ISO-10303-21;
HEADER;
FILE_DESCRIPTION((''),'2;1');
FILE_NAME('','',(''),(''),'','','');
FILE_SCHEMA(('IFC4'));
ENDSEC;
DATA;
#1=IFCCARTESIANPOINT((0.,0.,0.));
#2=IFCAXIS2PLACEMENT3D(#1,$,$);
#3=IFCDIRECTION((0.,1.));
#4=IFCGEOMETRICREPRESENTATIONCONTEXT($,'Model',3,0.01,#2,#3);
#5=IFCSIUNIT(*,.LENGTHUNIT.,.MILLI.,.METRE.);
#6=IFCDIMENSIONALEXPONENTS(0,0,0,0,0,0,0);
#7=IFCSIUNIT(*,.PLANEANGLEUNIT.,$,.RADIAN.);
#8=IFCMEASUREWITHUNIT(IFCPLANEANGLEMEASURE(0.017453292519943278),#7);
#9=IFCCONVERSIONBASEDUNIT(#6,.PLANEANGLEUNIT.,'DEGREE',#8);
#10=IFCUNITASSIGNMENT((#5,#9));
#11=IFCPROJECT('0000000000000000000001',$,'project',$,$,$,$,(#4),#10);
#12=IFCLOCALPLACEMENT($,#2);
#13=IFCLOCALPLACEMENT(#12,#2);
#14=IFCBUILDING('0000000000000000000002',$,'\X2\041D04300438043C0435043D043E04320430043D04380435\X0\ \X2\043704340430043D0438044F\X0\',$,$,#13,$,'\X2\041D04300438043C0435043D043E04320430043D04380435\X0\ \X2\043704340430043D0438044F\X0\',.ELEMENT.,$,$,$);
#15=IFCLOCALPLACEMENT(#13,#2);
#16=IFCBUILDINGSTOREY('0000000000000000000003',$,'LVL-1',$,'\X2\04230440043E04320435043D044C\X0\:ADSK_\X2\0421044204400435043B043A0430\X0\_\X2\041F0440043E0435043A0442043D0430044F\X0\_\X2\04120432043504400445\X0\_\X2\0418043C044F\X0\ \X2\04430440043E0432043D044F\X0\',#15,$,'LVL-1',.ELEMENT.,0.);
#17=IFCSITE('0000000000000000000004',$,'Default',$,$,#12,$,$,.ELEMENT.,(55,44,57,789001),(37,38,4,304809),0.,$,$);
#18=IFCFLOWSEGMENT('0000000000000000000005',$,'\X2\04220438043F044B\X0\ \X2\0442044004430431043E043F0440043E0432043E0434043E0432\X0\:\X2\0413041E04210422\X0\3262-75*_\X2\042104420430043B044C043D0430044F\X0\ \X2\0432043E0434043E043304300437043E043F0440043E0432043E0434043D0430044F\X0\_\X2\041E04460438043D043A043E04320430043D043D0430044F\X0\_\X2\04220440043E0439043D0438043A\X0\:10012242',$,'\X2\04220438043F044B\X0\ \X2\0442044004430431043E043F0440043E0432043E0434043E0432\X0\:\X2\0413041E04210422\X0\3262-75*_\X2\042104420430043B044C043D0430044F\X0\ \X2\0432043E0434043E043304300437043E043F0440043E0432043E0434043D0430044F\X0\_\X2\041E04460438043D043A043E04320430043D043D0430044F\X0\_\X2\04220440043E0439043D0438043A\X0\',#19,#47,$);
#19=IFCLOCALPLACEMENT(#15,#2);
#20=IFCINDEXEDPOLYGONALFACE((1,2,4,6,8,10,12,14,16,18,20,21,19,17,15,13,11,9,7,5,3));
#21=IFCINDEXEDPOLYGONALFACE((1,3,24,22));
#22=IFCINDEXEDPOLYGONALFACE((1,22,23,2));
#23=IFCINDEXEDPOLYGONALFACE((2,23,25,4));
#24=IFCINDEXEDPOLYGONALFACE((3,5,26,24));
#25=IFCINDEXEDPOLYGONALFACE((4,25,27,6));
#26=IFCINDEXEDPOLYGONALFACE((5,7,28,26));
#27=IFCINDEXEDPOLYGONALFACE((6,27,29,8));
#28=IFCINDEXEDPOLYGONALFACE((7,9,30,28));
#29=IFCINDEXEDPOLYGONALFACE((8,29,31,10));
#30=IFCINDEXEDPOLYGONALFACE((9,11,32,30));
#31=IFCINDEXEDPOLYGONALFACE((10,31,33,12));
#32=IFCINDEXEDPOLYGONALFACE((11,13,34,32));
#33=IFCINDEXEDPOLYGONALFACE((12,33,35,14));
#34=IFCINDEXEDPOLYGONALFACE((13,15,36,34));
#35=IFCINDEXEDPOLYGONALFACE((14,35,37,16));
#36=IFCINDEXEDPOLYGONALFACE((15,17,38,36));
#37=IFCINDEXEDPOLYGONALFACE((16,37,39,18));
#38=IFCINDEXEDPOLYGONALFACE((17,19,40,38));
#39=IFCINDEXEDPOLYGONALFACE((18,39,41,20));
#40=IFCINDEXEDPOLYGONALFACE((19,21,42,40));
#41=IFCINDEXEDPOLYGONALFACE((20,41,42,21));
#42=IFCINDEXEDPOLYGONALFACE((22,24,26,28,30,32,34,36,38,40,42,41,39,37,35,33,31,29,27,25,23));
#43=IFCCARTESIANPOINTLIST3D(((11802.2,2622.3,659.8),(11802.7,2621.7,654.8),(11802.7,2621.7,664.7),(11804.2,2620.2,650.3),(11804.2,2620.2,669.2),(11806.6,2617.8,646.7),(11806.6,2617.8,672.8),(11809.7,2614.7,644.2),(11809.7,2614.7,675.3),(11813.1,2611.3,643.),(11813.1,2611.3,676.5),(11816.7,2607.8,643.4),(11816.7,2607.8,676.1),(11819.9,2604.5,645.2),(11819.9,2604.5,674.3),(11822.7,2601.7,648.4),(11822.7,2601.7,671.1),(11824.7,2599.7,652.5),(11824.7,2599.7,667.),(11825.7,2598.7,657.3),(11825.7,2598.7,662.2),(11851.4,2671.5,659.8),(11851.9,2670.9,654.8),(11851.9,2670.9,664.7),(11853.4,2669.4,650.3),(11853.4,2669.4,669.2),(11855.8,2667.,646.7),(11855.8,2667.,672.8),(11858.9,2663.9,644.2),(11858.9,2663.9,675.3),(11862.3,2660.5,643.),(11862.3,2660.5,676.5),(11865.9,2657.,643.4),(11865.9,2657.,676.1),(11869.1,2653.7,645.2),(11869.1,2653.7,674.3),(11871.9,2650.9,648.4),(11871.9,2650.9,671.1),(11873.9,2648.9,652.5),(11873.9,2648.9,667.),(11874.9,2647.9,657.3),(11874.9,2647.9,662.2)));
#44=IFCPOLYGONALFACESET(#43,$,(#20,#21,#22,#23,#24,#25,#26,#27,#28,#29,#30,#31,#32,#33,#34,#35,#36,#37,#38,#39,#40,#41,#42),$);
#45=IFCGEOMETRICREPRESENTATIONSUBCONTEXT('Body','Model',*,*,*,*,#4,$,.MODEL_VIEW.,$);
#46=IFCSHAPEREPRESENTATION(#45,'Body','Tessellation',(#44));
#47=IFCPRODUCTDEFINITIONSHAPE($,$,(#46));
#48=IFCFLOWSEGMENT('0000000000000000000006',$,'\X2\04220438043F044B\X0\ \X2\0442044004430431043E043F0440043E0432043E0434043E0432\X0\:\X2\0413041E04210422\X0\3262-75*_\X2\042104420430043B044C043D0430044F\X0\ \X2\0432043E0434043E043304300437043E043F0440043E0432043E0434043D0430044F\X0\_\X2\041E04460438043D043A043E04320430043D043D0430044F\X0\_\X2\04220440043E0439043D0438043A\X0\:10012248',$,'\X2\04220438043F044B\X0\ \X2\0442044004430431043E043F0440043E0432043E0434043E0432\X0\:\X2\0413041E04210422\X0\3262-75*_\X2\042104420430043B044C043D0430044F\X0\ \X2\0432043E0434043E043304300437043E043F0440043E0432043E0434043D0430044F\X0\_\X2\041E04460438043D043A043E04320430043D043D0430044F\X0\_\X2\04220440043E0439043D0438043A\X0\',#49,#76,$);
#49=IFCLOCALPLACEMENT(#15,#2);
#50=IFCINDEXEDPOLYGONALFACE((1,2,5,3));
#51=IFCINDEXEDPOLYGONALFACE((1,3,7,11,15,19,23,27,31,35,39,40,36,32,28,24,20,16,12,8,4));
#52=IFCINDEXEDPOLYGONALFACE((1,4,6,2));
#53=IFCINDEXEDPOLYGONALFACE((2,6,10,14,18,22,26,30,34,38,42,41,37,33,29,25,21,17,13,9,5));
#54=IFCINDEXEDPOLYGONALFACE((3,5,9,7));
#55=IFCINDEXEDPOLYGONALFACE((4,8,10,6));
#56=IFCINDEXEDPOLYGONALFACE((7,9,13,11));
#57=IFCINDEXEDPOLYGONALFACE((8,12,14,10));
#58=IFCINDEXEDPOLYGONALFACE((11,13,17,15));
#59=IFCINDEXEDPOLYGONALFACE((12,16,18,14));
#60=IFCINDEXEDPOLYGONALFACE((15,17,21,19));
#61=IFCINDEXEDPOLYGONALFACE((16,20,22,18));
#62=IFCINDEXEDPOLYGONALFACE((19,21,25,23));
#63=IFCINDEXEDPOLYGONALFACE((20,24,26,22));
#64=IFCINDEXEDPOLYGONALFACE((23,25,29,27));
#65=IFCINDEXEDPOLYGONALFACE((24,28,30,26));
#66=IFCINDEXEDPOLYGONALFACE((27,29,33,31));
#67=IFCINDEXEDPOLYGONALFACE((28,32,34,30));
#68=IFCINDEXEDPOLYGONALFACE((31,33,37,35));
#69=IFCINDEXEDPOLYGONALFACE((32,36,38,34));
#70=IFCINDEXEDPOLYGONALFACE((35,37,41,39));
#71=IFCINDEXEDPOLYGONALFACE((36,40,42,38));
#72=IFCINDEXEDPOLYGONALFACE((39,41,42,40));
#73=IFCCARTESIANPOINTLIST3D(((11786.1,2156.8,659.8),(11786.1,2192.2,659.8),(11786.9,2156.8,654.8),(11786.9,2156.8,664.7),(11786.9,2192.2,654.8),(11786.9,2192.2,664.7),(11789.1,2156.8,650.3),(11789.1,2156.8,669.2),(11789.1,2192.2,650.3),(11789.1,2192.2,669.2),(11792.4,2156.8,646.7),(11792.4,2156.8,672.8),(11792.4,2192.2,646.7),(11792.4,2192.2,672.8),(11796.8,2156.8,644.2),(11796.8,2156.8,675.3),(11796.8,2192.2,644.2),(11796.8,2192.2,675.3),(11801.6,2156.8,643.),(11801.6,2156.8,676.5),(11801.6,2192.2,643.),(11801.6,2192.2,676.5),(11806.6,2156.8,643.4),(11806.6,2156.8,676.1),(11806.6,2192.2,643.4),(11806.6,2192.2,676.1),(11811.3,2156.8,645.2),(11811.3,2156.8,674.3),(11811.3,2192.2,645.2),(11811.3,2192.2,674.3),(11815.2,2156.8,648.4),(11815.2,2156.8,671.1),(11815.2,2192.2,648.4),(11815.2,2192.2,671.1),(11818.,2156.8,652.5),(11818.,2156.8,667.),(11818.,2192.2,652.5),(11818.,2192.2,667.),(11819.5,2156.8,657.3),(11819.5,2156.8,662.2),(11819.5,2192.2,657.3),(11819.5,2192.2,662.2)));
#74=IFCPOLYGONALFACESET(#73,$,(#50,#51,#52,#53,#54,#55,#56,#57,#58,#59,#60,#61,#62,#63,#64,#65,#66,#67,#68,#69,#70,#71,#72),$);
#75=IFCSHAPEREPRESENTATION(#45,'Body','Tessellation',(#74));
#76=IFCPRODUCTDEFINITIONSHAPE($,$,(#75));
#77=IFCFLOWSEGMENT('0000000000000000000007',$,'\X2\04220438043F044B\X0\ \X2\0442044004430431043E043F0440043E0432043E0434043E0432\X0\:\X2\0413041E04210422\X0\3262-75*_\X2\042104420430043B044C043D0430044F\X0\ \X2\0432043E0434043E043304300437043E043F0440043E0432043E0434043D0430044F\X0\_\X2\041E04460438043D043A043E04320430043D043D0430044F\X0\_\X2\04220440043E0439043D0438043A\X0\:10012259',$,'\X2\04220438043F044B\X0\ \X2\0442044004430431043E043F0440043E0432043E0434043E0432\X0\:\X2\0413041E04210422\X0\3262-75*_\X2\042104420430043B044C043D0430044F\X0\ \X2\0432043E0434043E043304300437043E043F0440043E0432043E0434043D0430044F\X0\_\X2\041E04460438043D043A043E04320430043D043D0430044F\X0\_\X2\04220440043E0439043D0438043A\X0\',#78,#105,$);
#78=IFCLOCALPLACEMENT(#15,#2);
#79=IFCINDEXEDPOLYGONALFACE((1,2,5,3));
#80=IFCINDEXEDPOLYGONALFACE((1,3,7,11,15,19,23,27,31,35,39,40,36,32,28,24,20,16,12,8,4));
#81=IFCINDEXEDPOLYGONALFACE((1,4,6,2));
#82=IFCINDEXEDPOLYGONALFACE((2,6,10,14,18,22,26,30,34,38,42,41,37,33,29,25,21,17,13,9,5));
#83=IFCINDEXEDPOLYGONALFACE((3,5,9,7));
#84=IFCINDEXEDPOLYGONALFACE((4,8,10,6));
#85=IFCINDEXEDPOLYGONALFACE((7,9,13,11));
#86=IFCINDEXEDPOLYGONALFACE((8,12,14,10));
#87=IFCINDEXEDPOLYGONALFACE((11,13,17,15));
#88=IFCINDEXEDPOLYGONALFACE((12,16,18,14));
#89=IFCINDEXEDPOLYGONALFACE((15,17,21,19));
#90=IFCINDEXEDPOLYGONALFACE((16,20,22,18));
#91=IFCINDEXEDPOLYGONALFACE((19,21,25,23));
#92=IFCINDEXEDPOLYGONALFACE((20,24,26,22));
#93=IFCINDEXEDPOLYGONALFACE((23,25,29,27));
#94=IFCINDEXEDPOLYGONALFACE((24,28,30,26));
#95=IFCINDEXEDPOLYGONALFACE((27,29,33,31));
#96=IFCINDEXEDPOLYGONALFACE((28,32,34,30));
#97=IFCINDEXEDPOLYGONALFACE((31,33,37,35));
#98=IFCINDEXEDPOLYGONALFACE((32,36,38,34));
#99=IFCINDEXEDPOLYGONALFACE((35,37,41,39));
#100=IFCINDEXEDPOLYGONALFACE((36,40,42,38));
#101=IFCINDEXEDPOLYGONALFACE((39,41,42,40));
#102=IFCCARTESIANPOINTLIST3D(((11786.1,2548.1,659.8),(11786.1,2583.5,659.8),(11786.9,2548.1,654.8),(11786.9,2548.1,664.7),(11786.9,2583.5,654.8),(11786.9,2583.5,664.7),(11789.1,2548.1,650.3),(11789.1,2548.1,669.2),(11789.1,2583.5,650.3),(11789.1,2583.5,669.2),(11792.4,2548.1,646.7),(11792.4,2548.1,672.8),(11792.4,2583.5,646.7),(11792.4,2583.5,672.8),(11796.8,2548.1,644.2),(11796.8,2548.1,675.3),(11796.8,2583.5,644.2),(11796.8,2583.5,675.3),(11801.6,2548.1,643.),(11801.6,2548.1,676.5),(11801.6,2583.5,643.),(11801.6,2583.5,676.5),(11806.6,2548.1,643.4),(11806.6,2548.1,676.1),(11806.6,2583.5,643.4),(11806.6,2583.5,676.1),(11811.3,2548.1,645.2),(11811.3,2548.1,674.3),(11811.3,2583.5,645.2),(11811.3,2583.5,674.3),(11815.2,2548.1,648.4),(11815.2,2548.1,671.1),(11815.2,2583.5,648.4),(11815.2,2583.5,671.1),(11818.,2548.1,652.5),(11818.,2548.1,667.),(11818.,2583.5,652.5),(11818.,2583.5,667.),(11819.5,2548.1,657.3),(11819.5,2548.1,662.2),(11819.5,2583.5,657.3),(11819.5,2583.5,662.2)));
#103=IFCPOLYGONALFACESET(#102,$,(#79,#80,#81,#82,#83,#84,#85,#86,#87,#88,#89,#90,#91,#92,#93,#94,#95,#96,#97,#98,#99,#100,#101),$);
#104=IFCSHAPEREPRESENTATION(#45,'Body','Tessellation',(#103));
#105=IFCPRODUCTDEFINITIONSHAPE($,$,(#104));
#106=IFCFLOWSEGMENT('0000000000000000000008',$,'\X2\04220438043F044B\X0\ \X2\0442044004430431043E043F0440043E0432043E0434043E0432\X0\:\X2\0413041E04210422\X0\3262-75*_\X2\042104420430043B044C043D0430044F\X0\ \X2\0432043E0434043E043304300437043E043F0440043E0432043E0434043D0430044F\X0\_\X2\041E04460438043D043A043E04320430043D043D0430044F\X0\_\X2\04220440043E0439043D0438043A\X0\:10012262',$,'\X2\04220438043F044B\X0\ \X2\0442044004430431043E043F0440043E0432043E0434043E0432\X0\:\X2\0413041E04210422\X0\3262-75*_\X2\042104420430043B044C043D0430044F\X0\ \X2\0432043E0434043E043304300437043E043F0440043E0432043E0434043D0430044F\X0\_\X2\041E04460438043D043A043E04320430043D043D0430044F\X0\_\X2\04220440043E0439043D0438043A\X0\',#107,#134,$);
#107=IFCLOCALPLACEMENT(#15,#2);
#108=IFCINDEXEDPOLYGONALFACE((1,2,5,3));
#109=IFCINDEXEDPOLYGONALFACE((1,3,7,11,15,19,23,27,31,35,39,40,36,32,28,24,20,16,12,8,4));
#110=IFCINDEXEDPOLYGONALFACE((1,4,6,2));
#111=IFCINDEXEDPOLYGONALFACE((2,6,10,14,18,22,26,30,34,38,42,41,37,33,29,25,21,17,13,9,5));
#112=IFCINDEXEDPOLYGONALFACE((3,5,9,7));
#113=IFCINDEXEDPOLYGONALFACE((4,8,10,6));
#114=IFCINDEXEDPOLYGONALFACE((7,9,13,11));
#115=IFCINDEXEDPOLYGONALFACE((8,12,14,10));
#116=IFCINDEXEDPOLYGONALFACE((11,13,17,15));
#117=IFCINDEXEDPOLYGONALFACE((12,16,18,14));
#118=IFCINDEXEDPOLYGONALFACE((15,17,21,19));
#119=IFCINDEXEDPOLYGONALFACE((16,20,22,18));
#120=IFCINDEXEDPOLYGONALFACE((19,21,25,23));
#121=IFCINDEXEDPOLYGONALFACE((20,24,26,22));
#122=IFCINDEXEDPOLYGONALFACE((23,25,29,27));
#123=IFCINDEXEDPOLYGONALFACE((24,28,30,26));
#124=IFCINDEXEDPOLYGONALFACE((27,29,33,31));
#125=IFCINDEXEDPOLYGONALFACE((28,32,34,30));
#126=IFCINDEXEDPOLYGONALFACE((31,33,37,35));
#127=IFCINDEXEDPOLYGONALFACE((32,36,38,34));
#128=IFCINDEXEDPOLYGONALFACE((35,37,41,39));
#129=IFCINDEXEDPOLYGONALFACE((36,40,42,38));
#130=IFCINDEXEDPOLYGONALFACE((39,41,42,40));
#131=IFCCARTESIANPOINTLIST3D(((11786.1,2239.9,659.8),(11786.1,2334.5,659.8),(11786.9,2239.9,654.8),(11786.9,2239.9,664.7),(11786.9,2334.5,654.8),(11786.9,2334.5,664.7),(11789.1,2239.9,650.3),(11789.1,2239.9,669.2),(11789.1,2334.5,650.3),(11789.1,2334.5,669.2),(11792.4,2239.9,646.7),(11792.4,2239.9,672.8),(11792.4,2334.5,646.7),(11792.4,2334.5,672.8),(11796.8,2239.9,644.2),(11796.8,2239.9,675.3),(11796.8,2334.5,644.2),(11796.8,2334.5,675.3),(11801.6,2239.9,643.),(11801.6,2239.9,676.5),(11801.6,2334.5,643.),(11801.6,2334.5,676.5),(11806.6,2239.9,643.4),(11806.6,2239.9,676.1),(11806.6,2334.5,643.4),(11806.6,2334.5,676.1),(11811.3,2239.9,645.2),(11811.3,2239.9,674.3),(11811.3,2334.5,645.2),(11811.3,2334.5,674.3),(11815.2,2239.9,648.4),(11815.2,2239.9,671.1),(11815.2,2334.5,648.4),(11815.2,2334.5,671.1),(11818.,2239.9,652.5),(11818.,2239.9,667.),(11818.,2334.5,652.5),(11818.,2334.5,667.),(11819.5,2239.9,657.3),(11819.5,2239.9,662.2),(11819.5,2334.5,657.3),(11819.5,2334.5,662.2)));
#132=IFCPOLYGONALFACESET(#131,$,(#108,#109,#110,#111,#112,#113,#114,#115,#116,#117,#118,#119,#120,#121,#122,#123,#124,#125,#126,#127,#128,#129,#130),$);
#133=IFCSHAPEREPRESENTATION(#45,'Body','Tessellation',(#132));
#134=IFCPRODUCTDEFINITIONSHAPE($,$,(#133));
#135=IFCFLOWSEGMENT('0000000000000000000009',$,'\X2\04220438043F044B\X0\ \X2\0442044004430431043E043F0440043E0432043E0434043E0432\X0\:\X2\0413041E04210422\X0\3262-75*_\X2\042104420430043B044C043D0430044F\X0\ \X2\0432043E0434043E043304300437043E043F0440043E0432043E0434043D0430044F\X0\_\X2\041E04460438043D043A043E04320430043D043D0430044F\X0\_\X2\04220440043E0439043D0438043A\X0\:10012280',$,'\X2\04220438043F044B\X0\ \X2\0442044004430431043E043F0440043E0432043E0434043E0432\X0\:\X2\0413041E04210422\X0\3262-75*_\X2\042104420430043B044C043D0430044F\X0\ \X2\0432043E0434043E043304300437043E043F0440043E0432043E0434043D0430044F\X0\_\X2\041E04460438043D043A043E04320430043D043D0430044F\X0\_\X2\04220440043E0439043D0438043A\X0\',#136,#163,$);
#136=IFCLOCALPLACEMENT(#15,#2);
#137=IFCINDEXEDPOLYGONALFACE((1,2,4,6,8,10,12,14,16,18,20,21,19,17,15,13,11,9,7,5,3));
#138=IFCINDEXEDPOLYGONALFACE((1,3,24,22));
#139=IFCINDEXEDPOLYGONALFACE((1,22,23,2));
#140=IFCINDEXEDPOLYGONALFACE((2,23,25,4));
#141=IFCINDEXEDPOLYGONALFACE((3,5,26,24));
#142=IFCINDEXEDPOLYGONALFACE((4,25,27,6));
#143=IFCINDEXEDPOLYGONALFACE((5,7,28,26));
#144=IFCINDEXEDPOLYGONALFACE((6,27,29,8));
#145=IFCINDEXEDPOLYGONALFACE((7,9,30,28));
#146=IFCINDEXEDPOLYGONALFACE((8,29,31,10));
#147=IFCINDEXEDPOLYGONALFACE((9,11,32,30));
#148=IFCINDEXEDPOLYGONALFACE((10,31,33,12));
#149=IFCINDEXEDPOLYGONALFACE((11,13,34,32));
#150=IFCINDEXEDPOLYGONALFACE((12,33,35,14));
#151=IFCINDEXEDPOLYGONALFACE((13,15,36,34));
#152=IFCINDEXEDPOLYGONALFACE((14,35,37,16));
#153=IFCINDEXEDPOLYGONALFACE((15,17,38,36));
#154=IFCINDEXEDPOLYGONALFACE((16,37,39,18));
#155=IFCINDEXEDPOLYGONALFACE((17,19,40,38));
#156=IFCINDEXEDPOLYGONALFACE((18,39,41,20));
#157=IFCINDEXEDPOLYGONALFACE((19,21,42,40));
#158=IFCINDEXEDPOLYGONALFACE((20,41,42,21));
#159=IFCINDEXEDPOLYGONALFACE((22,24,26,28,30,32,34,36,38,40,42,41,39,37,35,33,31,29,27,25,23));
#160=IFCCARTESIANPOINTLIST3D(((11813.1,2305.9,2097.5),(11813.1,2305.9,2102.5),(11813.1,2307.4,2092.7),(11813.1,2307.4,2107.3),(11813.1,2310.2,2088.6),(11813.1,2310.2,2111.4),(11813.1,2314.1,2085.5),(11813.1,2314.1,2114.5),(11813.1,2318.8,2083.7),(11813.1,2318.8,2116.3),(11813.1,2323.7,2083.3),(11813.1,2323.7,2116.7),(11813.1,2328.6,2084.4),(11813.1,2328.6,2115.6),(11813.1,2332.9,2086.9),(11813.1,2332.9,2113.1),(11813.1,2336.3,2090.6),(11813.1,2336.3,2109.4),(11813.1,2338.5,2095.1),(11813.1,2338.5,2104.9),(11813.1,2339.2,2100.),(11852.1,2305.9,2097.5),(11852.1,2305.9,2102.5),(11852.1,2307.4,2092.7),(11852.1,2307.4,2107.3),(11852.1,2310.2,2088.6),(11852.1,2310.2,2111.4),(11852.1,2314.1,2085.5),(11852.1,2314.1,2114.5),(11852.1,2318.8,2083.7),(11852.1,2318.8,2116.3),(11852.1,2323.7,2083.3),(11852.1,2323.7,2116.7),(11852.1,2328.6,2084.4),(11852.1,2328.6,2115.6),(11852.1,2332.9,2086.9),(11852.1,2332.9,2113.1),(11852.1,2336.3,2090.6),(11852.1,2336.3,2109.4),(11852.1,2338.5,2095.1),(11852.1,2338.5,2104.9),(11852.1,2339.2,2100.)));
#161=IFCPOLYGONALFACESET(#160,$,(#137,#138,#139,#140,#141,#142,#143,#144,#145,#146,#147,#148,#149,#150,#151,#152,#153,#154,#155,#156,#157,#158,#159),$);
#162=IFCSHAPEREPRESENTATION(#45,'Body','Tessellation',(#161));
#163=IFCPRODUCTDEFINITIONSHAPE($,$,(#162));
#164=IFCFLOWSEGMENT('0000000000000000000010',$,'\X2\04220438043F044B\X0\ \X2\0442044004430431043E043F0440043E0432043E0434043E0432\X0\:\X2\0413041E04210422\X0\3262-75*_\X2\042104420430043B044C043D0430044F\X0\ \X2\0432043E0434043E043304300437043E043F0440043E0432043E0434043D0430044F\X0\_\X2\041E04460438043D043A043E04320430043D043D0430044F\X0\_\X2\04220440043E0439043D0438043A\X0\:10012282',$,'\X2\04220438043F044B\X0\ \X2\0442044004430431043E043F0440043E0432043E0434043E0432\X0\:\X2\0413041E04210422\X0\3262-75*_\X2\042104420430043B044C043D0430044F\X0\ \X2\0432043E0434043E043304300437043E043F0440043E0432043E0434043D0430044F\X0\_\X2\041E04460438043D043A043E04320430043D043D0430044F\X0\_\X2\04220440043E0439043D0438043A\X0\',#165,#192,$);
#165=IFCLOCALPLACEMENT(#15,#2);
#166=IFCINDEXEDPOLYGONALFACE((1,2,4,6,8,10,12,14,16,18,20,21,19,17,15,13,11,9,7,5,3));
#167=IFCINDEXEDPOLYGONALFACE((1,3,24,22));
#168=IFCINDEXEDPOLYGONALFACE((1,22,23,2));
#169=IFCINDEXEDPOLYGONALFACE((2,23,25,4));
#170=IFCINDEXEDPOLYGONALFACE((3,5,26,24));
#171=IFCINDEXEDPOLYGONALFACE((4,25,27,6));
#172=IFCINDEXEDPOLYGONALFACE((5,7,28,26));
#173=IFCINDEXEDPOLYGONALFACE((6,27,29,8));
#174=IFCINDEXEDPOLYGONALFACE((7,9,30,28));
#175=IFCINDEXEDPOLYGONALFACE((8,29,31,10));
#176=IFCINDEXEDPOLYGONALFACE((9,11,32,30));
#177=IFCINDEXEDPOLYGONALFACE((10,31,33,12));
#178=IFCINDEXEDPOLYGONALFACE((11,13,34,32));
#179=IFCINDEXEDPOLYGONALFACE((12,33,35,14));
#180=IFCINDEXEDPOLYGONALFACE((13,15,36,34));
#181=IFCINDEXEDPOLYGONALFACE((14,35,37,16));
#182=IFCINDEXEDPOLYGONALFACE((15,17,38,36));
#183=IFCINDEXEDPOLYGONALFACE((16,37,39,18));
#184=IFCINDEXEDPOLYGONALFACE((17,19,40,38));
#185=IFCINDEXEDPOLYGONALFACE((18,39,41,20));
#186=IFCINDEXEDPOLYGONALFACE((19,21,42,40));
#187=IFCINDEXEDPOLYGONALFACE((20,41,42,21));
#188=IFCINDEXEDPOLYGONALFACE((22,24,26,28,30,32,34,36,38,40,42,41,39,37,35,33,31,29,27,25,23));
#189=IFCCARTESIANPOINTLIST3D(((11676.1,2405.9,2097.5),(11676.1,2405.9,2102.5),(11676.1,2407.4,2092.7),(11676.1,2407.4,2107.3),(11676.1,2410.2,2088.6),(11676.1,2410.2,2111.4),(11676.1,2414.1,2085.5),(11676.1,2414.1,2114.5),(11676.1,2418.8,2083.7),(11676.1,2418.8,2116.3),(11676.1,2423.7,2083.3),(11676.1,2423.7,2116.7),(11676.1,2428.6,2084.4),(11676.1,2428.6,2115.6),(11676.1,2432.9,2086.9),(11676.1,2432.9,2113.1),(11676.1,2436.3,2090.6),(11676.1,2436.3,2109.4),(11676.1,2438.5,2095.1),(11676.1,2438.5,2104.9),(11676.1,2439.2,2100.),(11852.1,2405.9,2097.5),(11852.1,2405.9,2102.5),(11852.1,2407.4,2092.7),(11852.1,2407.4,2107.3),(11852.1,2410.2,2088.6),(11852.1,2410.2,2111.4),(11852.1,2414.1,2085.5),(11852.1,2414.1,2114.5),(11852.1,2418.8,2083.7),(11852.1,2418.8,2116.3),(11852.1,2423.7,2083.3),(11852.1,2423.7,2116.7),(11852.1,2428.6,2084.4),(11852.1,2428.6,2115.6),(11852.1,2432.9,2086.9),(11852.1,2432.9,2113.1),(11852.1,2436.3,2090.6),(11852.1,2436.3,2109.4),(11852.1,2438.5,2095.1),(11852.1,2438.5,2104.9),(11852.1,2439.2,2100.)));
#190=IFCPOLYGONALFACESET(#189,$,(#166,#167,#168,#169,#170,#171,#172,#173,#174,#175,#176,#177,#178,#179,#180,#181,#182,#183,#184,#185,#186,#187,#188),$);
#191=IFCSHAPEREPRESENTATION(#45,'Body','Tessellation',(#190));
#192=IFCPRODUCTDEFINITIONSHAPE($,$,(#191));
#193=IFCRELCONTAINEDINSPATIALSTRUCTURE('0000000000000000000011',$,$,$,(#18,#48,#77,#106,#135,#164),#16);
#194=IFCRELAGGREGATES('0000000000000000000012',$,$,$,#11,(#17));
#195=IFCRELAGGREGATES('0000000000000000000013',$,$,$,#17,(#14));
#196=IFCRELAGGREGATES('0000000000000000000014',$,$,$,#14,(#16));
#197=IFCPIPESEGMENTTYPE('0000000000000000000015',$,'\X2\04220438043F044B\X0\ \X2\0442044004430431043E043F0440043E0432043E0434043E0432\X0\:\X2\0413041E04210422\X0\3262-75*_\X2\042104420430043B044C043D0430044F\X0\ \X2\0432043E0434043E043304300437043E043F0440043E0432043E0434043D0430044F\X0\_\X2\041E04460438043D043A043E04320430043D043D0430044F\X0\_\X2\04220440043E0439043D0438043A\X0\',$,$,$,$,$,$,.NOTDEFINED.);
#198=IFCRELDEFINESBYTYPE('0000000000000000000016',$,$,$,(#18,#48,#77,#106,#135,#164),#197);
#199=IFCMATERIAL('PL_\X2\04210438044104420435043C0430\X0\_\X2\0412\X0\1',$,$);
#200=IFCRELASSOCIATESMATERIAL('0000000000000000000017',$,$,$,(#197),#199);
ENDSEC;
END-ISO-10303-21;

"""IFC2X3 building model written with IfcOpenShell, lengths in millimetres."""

from ifc_helpers import new_model, entity, si_unit, converted_unit, direction, frame, frame_2d, origin, origin_2d_with_axis, place, context, subcontext, project, spatial, circle, extrude, material, type_object, element, save


model = new_model("IFC2X3")

# Units and contexts
model_context = context("Model", 3, precision=0.01, world=origin(), true_north=direction((0.0, 1.0)))
body_context = subcontext(model_context, "Body", "Model", "MODEL_VIEW")
ifc_project = project(units=[si_unit("LENGTHUNIT", "METRE", prefix="MILLI"), converted_unit("PLANEANGLEUNIT", "DEGREE", entity("IfcPlaneAngleMeasure", 0.017453292519943278), si_unit("PLANEANGLEUNIT", "RADIAN"), dimensions=[0, 0, 0, 0, 0, 0, 0])], contexts=[model_context])

# Site, building, storey
site_placement = place(None, origin())
site = spatial("IfcSite", under=ifc_project, at=site_placement, Name="Default", CompositionType="ELEMENT", RefLatitude=(55, 44, 57, 789001), RefLongitude=(37, 38, 4, 304809), RefElevation=0.0)
building_placement = place(site_placement, origin())
building = spatial("IfcBuilding", under=site, at=building_placement, Name="Наименование здания", LongName="Наименование здания", CompositionType="ELEMENT")
storey_placement = place(building_placement, origin())
storey = spatial("IfcBuildingStorey", under=building, at=storey_placement, Name="LVL-1", ObjectType="Уровень:ADSK_Стрелка_Проектная_Вверх_Имя уровня", LongName="LVL-1", CompositionType="ELEMENT", Elevation=0.0)

# Flow segments
ifc_material_1 = material(Name="PL_Система_В1")
pipe_segment_type_1 = type_object("IfcPipeSegmentType", Name="Типы трубопроводов:ГОСТ3262-75*_Стальная водогазопроводная_Оцинкованная_Тройник", PredefinedType="NOTDEFINED", material=ifc_material_1)
flow_segment_1_placement = place(storey_placement, origin())
element("IfcFlowSegment", 1, at=flow_segment_1_placement, inside=storey, type_object=pipe_segment_type_1, Name="Типы трубопроводов:ГОСТ3262-75*_Стальная водогазопроводная_Оцинкованная_Тройник:10012242", ObjectType="Типы трубопроводов:ГОСТ3262-75*_Стальная водогазопроводная_Оцинкованная_Тройник", context=body_context, shape_type="SweptSolid", body=[
    extrude(circle(Radius=16.8, at=frame_2d((0.0, 0.0), x_axis=(1.0, 0.0))), frame((11814.0, 2610.4, 659.8), z_axis=(0.707107, 0.707107, 0.0), x_axis=(-0.707107, 0.707107, 0.0)), (0.0, 0.0, 1.0), 69.6),
])
flow_segment_2_placement = place(storey_placement, origin())
element("IfcFlowSegment", 2, at=flow_segment_2_placement, inside=storey, type_object=pipe_segment_type_1, Name="Типы трубопроводов:ГОСТ3262-75*_Стальная водогазопроводная_Оцинкованная_Тройник:10012248", ObjectType="Типы трубопроводов:ГОСТ3262-75*_Стальная водогазопроводная_Оцинкованная_Тройник", context=body_context, shape_type="SweptSolid", body=[
    extrude(circle(Radius=16.8, at=frame_2d((0.0, 0.0), x_axis=(1.0, 0.0))), frame((11802.9, 2156.8, 659.8), z_axis=(0.0, 1.0, 0.0), x_axis=(-1.0, 0.0, 0.0)), (0.0, 0.0, 1.0), 35.4),
])
flow_segment_3_placement = place(storey_placement, origin())
element("IfcFlowSegment", 3, at=flow_segment_3_placement, inside=storey, type_object=pipe_segment_type_1, Name="Типы трубопроводов:ГОСТ3262-75*_Стальная водогазопроводная_Оцинкованная_Тройник:10012259", ObjectType="Типы трубопроводов:ГОСТ3262-75*_Стальная водогазопроводная_Оцинкованная_Тройник", context=body_context, shape_type="SweptSolid", body=[
    extrude(circle(Radius=16.8, at=origin_2d_with_axis()), frame((11802.9, 2548.1, 659.8), z_axis=(0.0, 1.0, 0.0), x_axis=(-1.0, 0.0, 0.0)), (0.0, 0.0, 1.0), 35.4),
])
flow_segment_4_placement = place(storey_placement, origin())
element("IfcFlowSegment", 4, at=flow_segment_4_placement, inside=storey, type_object=pipe_segment_type_1, Name="Типы трубопроводов:ГОСТ3262-75*_Стальная водогазопроводная_Оцинкованная_Тройник:10012262", ObjectType="Типы трубопроводов:ГОСТ3262-75*_Стальная водогазопроводная_Оцинкованная_Тройник", context=body_context, shape_type="SweptSolid", body=[
    extrude(circle(Radius=16.8, at=frame_2d((0.0, 0.0), x_axis=(1.0, 0.0))), frame((11802.9, 2239.9, 659.8), z_axis=(0.0, 1.0, 0.0), x_axis=(-1.0, 0.0, 0.0)), (0.0, 0.0, 1.0), 94.6),
])
flow_segment_5_placement = place(storey_placement, origin())
element("IfcFlowSegment", 5, at=flow_segment_5_placement, inside=storey, type_object=pipe_segment_type_1, Name="Типы трубопроводов:ГОСТ3262-75*_Стальная водогазопроводная_Оцинкованная_Тройник:10012280", ObjectType="Типы трубопроводов:ГОСТ3262-75*_Стальная водогазопроводная_Оцинкованная_Тройник", context=body_context, shape_type="SweptSolid", body=[
    extrude(circle(Radius=16.8, at=frame_2d((0.0, 0.0), x_axis=(1.0, 0.0))), frame((11813.1, 2322.5, 2100.0), z_axis=(1.0, 0.0, 0.0), x_axis=(0.0, 1.0, 0.0)), (0.0, 0.0, 1.0), 39.0),
])
flow_segment_6_placement = place(storey_placement, origin())
element("IfcFlowSegment", 6, at=flow_segment_6_placement, inside=storey, type_object=pipe_segment_type_1, Name="Типы трубопроводов:ГОСТ3262-75*_Стальная водогазопроводная_Оцинкованная_Тройник:10012282", ObjectType="Типы трубопроводов:ГОСТ3262-75*_Стальная водогазопроводная_Оцинкованная_Тройник", context=body_context, shape_type="SweptSolid", body=[
    extrude(circle(Radius=16.8, at=frame_2d((0.0, 0.0), x_axis=(1.0, 0.0))), frame((11676.1, 2422.5, 2100.0), z_axis=(1.0, 0.0, 0.0), x_axis=(0.0, 1.0, 0.0)), (0.0, 0.0, 1.0), 176.0),
])

save(model, "model.ifc")
